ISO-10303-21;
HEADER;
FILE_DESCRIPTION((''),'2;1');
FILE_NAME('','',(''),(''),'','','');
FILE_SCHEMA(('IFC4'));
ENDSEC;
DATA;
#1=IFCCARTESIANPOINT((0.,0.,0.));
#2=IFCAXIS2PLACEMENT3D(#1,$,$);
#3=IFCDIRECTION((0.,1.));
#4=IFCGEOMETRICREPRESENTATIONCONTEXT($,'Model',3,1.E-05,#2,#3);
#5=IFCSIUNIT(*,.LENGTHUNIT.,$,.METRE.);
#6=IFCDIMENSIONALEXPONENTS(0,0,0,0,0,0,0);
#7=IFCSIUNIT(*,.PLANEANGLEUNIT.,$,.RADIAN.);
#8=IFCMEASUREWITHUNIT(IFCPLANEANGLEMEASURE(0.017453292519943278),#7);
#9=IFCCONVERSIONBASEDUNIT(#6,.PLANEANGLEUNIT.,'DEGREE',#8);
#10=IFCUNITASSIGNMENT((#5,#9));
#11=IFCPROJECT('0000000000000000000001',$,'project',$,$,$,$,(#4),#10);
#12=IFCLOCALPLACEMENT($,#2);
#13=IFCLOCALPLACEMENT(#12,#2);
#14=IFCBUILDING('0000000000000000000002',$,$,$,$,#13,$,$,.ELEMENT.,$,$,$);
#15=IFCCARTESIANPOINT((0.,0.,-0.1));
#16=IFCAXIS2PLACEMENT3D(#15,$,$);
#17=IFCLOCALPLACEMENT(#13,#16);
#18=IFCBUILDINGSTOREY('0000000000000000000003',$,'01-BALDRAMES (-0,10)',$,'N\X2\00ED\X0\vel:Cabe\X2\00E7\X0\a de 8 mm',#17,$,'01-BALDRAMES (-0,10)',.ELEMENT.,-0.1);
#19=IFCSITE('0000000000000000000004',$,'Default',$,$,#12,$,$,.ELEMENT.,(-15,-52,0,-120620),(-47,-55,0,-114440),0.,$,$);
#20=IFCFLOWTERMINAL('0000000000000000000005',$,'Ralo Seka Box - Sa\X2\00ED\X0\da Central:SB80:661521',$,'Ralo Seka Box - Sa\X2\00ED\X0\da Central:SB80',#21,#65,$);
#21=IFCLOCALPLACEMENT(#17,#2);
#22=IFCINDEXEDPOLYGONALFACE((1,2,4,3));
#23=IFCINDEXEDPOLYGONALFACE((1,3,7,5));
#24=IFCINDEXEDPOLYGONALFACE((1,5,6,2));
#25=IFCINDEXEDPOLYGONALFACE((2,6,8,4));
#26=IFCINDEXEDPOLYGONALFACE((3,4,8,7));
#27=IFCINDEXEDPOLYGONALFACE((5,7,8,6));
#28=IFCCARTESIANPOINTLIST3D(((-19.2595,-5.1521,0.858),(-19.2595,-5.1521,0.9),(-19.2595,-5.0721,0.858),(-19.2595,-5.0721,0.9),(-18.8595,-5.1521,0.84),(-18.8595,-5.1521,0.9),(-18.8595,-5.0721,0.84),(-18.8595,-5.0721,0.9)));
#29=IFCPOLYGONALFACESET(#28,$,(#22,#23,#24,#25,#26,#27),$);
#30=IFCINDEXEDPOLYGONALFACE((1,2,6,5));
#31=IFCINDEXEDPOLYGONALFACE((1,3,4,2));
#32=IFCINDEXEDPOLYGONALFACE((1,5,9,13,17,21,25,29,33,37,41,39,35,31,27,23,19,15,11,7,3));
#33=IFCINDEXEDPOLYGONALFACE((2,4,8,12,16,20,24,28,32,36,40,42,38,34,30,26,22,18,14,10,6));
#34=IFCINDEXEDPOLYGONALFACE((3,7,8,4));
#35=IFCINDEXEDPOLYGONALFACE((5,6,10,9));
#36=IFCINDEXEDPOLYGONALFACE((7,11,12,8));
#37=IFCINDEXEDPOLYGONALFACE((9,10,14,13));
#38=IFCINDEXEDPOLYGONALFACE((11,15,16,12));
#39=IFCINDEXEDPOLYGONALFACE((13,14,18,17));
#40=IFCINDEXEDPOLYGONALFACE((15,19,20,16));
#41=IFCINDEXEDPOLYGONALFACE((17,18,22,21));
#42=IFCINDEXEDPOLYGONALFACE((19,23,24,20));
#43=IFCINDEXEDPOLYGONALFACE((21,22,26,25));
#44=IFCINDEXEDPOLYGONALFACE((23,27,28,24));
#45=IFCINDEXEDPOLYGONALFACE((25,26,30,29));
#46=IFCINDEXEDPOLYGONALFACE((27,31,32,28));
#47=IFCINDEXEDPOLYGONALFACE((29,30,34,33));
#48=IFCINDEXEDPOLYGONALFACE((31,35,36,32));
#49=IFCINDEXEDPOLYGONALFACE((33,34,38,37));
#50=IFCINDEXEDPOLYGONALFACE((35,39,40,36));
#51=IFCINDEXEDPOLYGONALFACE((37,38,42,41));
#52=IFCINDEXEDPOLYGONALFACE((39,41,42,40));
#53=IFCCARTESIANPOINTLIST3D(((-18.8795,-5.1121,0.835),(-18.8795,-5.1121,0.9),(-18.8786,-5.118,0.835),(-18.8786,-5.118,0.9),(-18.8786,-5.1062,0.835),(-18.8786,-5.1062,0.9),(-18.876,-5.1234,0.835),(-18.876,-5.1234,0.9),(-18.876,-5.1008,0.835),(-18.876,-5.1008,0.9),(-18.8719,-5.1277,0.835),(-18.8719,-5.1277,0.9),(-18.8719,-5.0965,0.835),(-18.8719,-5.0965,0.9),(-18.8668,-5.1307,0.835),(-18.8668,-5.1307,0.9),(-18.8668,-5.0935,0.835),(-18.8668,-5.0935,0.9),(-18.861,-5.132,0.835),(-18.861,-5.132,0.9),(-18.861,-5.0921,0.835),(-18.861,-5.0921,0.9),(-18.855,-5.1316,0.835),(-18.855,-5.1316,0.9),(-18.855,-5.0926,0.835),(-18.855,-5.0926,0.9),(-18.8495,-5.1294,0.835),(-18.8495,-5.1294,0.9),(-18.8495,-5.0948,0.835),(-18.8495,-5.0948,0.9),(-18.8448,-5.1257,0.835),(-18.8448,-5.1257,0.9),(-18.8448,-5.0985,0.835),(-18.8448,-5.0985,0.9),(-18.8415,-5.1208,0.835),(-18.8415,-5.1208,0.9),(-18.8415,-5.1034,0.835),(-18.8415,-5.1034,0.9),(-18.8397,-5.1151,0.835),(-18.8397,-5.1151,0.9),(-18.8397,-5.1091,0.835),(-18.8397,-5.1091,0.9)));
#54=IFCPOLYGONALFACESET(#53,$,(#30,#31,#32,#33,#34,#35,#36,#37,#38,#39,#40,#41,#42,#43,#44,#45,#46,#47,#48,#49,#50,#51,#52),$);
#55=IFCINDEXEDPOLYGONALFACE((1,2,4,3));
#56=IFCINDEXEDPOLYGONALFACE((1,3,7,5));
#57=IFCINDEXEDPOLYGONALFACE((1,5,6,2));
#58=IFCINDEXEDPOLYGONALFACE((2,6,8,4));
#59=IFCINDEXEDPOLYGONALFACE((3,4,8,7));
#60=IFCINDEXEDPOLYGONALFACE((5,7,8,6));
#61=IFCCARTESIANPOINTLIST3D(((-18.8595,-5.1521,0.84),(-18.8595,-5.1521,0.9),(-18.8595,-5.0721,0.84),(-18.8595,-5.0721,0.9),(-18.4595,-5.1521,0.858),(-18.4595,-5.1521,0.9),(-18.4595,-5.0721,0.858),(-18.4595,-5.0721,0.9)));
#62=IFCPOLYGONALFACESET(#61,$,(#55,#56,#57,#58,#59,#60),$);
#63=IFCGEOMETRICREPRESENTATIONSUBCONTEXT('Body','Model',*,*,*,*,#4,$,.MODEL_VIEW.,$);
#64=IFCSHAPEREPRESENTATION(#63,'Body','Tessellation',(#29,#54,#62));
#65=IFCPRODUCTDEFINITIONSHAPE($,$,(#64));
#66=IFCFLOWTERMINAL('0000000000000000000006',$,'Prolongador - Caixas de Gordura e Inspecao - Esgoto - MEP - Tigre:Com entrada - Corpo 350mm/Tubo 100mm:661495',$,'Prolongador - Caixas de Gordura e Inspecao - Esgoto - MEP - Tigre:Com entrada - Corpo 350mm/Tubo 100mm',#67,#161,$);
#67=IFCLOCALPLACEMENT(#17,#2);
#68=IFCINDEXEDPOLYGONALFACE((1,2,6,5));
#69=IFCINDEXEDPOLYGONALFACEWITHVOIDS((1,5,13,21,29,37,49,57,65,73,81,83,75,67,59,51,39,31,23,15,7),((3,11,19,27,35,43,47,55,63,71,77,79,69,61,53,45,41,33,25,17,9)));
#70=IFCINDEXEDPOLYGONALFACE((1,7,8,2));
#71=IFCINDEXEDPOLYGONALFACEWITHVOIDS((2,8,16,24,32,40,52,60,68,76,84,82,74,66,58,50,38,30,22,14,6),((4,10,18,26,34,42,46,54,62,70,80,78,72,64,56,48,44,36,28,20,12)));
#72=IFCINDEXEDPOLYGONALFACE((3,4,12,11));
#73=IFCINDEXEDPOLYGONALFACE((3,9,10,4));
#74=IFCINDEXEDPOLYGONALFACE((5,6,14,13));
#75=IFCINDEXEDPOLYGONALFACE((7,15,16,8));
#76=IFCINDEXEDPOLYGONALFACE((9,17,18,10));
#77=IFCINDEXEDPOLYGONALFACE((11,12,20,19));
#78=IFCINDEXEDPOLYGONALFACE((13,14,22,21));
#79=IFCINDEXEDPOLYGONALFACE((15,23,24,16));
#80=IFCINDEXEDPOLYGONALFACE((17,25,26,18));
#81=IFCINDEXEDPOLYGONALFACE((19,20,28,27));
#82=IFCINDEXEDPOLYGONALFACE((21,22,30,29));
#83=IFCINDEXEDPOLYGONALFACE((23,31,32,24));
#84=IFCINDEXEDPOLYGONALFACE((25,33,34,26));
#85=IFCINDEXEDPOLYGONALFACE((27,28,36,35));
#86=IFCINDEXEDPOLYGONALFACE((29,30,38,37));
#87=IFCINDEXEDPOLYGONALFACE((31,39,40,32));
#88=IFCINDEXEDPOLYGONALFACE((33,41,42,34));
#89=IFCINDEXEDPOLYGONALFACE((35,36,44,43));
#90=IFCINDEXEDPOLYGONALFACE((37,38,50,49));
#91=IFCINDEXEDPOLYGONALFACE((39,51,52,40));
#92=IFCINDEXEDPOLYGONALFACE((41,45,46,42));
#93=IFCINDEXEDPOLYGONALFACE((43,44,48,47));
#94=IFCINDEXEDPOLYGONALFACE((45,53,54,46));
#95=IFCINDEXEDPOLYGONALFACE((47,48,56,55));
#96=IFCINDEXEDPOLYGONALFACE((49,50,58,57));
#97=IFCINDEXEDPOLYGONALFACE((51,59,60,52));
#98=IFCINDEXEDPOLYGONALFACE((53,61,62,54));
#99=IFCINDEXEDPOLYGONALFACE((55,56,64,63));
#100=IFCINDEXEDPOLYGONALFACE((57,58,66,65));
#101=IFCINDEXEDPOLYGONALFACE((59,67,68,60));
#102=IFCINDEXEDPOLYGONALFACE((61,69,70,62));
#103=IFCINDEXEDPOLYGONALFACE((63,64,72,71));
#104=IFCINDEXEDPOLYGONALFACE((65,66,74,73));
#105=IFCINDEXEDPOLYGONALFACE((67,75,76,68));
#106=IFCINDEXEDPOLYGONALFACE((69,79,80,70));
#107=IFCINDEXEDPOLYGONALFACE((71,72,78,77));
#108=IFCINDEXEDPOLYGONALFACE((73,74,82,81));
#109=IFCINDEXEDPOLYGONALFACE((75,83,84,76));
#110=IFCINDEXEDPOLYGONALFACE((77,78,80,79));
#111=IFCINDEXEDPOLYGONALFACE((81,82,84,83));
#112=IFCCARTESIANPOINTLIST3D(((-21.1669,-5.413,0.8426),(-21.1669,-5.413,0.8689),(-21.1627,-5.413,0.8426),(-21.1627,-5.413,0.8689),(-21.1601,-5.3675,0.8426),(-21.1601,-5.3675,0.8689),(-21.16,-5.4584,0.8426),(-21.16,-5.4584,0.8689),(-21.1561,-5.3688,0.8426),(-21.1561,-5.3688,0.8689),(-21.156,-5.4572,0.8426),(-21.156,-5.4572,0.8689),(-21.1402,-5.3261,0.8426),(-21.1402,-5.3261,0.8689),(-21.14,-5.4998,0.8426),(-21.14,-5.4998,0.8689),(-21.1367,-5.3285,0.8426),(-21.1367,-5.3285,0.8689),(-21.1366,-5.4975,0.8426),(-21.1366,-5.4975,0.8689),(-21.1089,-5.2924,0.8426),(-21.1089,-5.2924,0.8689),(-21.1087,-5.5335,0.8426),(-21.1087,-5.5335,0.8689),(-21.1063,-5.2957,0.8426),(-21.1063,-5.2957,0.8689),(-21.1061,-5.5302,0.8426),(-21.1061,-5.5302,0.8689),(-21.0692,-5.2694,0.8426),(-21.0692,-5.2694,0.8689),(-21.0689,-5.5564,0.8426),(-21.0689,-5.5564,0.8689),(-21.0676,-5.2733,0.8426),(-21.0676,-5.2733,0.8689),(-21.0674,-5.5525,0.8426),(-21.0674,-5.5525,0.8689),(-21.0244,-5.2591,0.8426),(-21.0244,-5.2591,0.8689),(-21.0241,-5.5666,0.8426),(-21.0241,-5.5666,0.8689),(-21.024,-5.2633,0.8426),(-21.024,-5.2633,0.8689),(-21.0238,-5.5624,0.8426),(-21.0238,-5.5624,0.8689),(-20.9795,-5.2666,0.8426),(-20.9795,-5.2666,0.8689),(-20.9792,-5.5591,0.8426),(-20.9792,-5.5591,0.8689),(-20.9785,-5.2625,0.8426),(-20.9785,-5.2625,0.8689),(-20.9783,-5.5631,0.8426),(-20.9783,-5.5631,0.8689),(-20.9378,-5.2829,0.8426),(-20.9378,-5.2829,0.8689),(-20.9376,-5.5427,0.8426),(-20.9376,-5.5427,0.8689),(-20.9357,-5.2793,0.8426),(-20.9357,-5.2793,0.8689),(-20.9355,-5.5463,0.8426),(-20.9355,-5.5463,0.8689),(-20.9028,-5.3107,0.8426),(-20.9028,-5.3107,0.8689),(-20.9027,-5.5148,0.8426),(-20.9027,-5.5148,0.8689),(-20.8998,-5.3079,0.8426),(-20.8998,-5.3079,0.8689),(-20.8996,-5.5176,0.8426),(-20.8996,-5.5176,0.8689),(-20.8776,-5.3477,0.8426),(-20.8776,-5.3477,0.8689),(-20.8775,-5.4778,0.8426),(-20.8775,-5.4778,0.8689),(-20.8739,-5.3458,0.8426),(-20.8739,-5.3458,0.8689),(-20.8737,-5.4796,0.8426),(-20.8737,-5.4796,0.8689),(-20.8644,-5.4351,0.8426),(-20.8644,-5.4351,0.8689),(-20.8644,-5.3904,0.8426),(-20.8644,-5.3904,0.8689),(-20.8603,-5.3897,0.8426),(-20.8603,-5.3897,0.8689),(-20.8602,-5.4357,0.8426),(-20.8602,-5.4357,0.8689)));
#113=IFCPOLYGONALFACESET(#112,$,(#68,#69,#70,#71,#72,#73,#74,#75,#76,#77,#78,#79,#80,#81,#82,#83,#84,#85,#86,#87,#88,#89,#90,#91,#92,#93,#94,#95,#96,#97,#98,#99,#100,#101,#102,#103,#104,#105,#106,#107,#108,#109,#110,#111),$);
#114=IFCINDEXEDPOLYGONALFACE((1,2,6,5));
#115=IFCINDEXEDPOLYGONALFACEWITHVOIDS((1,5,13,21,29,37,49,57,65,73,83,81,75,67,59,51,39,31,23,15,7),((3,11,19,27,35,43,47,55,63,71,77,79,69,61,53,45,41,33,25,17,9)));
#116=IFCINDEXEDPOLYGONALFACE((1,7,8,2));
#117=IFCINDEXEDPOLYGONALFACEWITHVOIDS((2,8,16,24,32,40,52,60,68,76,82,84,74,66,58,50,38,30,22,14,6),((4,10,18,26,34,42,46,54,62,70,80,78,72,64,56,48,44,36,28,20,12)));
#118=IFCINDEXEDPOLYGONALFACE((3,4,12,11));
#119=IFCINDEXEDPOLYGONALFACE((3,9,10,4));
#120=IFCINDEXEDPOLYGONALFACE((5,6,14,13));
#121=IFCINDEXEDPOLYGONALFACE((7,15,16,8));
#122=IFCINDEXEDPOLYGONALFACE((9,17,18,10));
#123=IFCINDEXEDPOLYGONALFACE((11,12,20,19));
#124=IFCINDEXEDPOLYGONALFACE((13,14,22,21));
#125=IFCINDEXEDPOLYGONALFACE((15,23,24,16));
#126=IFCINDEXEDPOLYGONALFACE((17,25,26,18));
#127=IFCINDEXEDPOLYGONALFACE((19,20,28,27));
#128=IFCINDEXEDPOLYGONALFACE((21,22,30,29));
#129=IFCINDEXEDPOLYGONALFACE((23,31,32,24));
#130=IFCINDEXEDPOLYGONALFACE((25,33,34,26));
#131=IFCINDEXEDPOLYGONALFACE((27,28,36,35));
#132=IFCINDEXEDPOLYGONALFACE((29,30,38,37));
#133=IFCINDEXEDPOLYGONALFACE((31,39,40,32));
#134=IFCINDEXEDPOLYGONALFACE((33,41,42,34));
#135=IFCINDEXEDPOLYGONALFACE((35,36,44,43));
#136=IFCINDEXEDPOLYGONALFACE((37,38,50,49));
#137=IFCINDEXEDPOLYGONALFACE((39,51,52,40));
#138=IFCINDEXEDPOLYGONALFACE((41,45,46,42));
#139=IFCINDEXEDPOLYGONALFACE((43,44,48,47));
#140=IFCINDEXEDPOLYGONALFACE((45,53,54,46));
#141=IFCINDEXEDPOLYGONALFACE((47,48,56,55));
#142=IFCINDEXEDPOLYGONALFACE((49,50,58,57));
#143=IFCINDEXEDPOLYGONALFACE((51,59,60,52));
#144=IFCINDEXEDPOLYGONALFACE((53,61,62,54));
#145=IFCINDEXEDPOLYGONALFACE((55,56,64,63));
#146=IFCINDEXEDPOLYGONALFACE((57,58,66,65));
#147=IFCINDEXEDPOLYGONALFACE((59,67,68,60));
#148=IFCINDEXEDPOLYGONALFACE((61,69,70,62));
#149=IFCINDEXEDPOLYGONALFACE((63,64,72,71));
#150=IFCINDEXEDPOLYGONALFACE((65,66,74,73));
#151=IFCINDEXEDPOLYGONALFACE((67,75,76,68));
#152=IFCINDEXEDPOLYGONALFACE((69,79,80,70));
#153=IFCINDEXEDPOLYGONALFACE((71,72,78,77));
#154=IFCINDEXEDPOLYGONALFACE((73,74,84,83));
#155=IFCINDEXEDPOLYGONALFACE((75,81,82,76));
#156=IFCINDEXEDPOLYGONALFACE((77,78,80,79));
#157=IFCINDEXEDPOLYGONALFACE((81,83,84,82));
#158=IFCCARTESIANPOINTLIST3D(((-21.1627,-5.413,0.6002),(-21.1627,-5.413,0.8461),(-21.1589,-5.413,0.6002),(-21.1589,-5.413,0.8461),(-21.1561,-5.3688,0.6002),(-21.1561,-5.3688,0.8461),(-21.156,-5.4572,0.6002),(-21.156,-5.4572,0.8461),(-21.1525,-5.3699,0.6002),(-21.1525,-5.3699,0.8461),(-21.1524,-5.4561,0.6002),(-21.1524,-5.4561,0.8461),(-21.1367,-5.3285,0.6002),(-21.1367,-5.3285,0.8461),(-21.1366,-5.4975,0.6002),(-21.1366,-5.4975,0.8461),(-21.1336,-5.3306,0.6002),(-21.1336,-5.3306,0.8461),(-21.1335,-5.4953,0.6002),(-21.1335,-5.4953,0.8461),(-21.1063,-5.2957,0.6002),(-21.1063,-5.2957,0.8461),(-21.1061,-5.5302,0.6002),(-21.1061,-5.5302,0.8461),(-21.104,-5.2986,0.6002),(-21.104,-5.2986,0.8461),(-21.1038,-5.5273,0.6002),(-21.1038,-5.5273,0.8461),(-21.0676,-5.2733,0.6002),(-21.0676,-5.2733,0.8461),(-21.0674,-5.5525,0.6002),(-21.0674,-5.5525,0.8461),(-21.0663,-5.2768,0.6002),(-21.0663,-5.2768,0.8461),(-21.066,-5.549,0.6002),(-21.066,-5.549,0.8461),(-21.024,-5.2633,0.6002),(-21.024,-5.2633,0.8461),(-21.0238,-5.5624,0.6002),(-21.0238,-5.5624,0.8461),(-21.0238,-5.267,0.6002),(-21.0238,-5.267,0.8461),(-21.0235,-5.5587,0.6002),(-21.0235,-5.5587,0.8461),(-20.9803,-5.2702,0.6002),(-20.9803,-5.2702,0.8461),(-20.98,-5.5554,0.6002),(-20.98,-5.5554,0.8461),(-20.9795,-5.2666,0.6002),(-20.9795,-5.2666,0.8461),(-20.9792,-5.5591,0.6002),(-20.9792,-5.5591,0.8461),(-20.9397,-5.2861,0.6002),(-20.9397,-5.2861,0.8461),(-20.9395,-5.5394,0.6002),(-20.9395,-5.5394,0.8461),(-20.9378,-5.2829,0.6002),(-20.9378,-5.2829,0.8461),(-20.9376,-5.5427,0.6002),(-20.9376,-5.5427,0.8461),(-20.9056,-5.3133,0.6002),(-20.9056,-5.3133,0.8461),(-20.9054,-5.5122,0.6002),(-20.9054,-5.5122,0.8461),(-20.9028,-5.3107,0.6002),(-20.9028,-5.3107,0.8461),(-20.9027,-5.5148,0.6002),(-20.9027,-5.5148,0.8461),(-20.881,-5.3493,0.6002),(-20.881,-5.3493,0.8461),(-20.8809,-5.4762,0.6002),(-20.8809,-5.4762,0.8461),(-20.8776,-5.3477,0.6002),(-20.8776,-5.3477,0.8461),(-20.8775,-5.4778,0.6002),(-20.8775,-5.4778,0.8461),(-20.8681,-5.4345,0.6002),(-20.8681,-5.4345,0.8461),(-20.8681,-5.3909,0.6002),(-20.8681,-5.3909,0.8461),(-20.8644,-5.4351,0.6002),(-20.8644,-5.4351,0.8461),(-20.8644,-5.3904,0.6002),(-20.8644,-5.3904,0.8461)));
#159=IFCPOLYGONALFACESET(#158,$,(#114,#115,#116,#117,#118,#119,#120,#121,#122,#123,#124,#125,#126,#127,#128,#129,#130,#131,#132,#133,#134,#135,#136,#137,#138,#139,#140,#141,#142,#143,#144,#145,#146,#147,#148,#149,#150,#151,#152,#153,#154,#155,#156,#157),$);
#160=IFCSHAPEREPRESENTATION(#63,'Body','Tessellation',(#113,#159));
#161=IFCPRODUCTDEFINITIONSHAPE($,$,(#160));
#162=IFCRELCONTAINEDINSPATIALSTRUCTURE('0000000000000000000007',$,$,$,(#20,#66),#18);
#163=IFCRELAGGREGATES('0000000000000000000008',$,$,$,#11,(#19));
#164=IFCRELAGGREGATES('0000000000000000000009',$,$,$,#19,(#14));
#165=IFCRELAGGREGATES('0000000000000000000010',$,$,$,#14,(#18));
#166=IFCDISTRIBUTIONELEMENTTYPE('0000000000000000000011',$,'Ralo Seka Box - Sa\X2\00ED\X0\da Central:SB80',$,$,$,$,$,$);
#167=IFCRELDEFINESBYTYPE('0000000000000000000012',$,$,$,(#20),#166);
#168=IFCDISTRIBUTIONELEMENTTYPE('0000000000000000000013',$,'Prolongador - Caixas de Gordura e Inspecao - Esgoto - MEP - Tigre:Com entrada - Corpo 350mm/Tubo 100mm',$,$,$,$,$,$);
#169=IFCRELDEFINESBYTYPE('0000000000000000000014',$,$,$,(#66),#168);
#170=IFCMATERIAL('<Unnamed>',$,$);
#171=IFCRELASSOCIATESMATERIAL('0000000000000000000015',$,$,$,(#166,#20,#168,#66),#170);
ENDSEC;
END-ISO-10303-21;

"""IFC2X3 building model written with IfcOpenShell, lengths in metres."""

from ifc_helpers import new_model, entity, si_unit, converted_unit, direction, frame, frame_2d, origin, place, context, subcontext, project, spatial, polyline, circle, hollow_circle, outline, extrude, source, transform, mapped, material, type_object, type_shapes, element, save


model = new_model("IFC2X3")

# Units and contexts
model_context = context("Model", 3, precision=1e-05, world=origin(), true_north=direction((0.0, 1.0)))
body_context = subcontext(model_context, "Body", "Model", "MODEL_VIEW")
ifc_project = project(units=[si_unit("LENGTHUNIT", "METRE"), converted_unit("PLANEANGLEUNIT", "DEGREE", entity("IfcPlaneAngleMeasure", 0.017453292519943278), si_unit("PLANEANGLEUNIT", "RADIAN"), dimensions=[0, 0, 0, 0, 0, 0, 0])], contexts=[model_context])

# Site, building, storey
site_placement = place(None, origin())
site = spatial("IfcSite", under=ifc_project, at=site_placement, Name="Default", CompositionType="ELEMENT", RefLatitude=(-15, -52, 0, -120620), RefLongitude=(-47, -55, 0, -114440), RefElevation=0.0)
building_placement = place(site_placement, origin())
building = spatial("IfcBuilding", under=site, at=building_placement, CompositionType="ELEMENT")
storey_placement = place(building_placement, frame((0.0, 0.0, -0.1)))
storey = spatial("IfcBuildingStorey", under=building, at=storey_placement, Name="01-BALDRAMES (-0,10)", ObjectType="Nível:Cabeça de 8 mm", LongName="01-BALDRAMES (-0,10)", CompositionType="ELEMENT", Elevation=-0.1)

# Flow terminals
ifc_material = material(Name="<Unnamed>")
distribution_element_type_1 = type_object("IfcDistributionElementType", Name="Ralo Seka Box - Saída Central:SB80", material=ifc_material)
shared_shape_1 = source(origin(), body_context, "Body", "SweptSolid", [
    extrude(outline(polyline([(-0.1991, -0.0255), (0.2013, -0.0255), (0.1987, 0.0345), (-0.2009, 0.0165), (-0.1991, -0.0255)])), frame((0.2, -0.04, -0.0255), z_axis=(0.0, 1.0, 0.0), x_axis=(-0.998989, 0.0, -0.044955)), (0.0, 0.0, 1.0), 0.08),
    extrude(circle(Radius=0.02, at=frame_2d((0.0, 0.0), x_axis=(1.0, 0.0))), frame((0.0, 0.0, -0.065)), (0.0, 0.0, 1.0), 0.065),
    extrude(outline(polyline([(-0.2, -0.0255), (0.2, -0.0255), (0.2, 0.0345), (-0.2, 0.0165), (-0.2, -0.0255)])), frame((-0.2, -0.04, -0.0255), z_axis=(0.0, 1.0, 0.0), x_axis=(1.0, 0.0, 0.0)), (0.0, 0.0, 1.0), 0.08),
])
type_shapes(distribution_element_type_1, [shared_shape_1])
flow_terminal_1_placement = place(storey_placement, frame((-18.8595, -5.1121, 0.9), z_axis=(0.0, 0.0, 1.0), x_axis=(-1.0, -0.000001, 0.0)))
element("IfcFlowTerminal", 1, at=flow_terminal_1_placement, inside=storey, type_object=distribution_element_type_1, material=ifc_material, Name="Ralo Seka Box - Saída Central:SB80:661521", ObjectType="Ralo Seka Box - Saída Central:SB80", context=body_context, shape_type="MappedRepresentation", body=[
    mapped(shared_shape_1, transform((0.0, 0.0, 0.0), scale=1.0)),
])
distribution_element_type_2 = type_object("IfcDistributionElementType", Name="Prolongador - Caixas de Gordura e Inspecao - Esgoto - MEP - Tigre:Com entrada - Corpo 350mm/Tubo 100mm", material=ifc_material)
shared_shape_2 = source(origin(), body_context, "Body", "SweptSolid", [
    extrude(hollow_circle(Radius=0.1542, WallThickness=0.0042, at=frame_2d((0.0, 0.0), x_axis=(1.0, 0.0))), frame((0.0, 0.0, -0.0574), z_axis=(0.0, 0.0, 1.0), x_axis=(0.0, -1.0, 0.0)), (0.0, 0.0, 1.0), 0.0263),
    extrude(hollow_circle(Radius=0.15, WallThickness=0.0038, at=frame_2d((0.0, 0.0), x_axis=(1.0, 0.0))), frame((0.0, 0.0, -0.2998), z_axis=(0.0, 0.0, 1.0), x_axis=(0.0, -1.0, 0.0)), (0.0, 0.0, 1.0), 0.2459),
])
type_shapes(distribution_element_type_2, [shared_shape_2])
flow_terminal_2_placement = place(storey_placement, frame((-21.0127, -5.4129, 0.9), z_axis=(0.0, 0.0, 1.0), x_axis=(0.000878, -1.0, 0.0)))
element("IfcFlowTerminal", 2, at=flow_terminal_2_placement, inside=storey, type_object=distribution_element_type_2, material=ifc_material, Name="Prolongador - Caixas de Gordura e Inspecao - Esgoto - MEP - Tigre:Com entrada - Corpo 350mm/Tubo 100mm:661495", ObjectType="Prolongador - Caixas de Gordura e Inspecao - Esgoto - MEP - Tigre:Com entrada - Corpo 350mm/Tubo 100mm", context=body_context, shape_type="MappedRepresentation", body=[
    mapped(shared_shape_2, transform((0.0, 0.0, 0.0), scale=1.0)),
])

save(model, "model.ifc")
